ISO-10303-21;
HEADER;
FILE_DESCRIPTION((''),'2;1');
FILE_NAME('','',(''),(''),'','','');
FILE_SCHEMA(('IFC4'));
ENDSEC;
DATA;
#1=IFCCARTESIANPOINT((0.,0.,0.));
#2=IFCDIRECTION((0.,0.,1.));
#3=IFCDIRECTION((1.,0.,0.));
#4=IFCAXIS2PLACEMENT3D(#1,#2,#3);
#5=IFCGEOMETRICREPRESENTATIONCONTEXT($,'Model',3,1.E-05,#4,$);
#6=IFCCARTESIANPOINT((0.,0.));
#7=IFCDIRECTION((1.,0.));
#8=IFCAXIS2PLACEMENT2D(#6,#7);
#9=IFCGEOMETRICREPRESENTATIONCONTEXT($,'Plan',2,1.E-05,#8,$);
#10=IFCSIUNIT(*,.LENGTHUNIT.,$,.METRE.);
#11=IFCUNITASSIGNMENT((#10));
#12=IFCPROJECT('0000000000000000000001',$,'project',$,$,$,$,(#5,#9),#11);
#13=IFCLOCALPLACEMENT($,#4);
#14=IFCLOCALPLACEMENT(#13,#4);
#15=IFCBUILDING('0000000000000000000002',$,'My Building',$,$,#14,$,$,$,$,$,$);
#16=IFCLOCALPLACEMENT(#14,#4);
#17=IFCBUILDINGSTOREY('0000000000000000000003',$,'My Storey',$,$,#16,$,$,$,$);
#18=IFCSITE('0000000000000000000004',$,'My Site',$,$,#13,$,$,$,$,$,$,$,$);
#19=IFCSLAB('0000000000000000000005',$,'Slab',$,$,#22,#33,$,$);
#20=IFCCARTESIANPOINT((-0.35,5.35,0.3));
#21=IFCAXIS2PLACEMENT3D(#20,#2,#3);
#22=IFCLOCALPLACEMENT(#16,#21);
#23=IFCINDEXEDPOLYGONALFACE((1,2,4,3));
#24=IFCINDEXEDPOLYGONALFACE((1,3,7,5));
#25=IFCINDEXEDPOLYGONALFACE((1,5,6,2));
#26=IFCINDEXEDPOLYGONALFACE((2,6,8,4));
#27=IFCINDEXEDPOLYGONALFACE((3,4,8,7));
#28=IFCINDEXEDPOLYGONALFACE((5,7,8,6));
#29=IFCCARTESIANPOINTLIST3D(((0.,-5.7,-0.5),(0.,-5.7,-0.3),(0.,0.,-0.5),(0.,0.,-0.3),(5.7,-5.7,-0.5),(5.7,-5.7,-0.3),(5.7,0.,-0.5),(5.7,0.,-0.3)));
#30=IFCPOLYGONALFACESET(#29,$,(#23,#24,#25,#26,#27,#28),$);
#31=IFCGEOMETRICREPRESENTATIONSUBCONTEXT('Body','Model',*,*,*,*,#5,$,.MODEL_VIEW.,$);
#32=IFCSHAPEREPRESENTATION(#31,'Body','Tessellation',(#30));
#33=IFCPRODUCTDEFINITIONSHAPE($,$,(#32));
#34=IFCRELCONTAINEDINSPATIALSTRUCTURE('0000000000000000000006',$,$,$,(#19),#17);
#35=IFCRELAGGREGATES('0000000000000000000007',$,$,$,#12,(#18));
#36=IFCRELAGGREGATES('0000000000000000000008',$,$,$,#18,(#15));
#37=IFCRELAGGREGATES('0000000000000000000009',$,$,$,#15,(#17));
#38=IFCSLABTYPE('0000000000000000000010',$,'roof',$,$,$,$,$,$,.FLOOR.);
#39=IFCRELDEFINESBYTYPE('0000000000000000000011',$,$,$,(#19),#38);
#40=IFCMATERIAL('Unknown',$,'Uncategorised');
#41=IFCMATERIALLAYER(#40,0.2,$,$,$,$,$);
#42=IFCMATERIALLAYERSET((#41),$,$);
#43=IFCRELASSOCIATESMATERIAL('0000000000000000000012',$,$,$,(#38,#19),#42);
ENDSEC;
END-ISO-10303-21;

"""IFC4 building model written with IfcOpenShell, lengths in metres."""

from ifc_helpers import new_model, si_unit, frame, origin_with_axes, origin_2d_with_axis, place, context, subcontext, project, spatial, indexed_curve, outline, extrude, material, layer, layer_set, layer_usage, type_object, element, save


model = new_model("IFC4")

# Units and contexts
model_context = context("Model", 3, precision=1e-05, world=origin_with_axes())
plan_context = context("Plan", 2, precision=1e-05, world=origin_2d_with_axis())
body_context_1 = subcontext(model_context, "Body", "Model", "MODEL_VIEW")
ifc_project = project(units=[si_unit("LENGTHUNIT", "METRE")], contexts=[model_context, plan_context])

# Site, building, storey
site_placement = place(None, origin_with_axes())
site = spatial("IfcSite", under=ifc_project, at=site_placement, Name="My Site")
building_placement = place(site_placement, origin_with_axes())
building = spatial("IfcBuilding", under=site, at=building_placement, Name="My Building")
storey_placement = place(building_placement, origin_with_axes())
storey = spatial("IfcBuildingStorey", under=building, at=storey_placement, Name="My Storey")

# Shared definitions
ifc_material = material(Name="Unknown", Category="Uncategorised")

# Slab
ifc_layer_1 = layer(ifc_material, 0.2)
ifc_layer_set_1 = layer_set([ifc_layer_1])
ifc_layer_usage_1 = layer_usage(ifc_layer_set_1, "AXIS3", "POSITIVE", -0.5)
slab_type = type_object("IfcSlabType", Name="roof", PredefinedType="FLOOR", material=ifc_layer_set_1)
slab_placement = place(storey_placement, frame((-0.35, 5.35, 0.3), z_axis=(0.0, 0.0, 1.0), x_axis=(1.0, 0.0, 0.0)))
element("IfcSlab", 1, at=slab_placement, inside=storey, type_object=slab_type, material=ifc_layer_usage_1, Name="Slab", context=body_context_1, shape_type="SweptSolid", body=[
    extrude(outline(indexed_curve([(0.0, 0.0), (5.7, 0.0), (5.7, -5.7), (0.0, -5.7), (0.0, 0.0)])), frame((0.0, 0.0, -0.5), z_axis=(0.0, 0.0, 1.0), x_axis=(1.0, 0.0, 0.0)), (0.0, 0.0, 1.0), 0.2),
])

save(model, "model.ifc")
